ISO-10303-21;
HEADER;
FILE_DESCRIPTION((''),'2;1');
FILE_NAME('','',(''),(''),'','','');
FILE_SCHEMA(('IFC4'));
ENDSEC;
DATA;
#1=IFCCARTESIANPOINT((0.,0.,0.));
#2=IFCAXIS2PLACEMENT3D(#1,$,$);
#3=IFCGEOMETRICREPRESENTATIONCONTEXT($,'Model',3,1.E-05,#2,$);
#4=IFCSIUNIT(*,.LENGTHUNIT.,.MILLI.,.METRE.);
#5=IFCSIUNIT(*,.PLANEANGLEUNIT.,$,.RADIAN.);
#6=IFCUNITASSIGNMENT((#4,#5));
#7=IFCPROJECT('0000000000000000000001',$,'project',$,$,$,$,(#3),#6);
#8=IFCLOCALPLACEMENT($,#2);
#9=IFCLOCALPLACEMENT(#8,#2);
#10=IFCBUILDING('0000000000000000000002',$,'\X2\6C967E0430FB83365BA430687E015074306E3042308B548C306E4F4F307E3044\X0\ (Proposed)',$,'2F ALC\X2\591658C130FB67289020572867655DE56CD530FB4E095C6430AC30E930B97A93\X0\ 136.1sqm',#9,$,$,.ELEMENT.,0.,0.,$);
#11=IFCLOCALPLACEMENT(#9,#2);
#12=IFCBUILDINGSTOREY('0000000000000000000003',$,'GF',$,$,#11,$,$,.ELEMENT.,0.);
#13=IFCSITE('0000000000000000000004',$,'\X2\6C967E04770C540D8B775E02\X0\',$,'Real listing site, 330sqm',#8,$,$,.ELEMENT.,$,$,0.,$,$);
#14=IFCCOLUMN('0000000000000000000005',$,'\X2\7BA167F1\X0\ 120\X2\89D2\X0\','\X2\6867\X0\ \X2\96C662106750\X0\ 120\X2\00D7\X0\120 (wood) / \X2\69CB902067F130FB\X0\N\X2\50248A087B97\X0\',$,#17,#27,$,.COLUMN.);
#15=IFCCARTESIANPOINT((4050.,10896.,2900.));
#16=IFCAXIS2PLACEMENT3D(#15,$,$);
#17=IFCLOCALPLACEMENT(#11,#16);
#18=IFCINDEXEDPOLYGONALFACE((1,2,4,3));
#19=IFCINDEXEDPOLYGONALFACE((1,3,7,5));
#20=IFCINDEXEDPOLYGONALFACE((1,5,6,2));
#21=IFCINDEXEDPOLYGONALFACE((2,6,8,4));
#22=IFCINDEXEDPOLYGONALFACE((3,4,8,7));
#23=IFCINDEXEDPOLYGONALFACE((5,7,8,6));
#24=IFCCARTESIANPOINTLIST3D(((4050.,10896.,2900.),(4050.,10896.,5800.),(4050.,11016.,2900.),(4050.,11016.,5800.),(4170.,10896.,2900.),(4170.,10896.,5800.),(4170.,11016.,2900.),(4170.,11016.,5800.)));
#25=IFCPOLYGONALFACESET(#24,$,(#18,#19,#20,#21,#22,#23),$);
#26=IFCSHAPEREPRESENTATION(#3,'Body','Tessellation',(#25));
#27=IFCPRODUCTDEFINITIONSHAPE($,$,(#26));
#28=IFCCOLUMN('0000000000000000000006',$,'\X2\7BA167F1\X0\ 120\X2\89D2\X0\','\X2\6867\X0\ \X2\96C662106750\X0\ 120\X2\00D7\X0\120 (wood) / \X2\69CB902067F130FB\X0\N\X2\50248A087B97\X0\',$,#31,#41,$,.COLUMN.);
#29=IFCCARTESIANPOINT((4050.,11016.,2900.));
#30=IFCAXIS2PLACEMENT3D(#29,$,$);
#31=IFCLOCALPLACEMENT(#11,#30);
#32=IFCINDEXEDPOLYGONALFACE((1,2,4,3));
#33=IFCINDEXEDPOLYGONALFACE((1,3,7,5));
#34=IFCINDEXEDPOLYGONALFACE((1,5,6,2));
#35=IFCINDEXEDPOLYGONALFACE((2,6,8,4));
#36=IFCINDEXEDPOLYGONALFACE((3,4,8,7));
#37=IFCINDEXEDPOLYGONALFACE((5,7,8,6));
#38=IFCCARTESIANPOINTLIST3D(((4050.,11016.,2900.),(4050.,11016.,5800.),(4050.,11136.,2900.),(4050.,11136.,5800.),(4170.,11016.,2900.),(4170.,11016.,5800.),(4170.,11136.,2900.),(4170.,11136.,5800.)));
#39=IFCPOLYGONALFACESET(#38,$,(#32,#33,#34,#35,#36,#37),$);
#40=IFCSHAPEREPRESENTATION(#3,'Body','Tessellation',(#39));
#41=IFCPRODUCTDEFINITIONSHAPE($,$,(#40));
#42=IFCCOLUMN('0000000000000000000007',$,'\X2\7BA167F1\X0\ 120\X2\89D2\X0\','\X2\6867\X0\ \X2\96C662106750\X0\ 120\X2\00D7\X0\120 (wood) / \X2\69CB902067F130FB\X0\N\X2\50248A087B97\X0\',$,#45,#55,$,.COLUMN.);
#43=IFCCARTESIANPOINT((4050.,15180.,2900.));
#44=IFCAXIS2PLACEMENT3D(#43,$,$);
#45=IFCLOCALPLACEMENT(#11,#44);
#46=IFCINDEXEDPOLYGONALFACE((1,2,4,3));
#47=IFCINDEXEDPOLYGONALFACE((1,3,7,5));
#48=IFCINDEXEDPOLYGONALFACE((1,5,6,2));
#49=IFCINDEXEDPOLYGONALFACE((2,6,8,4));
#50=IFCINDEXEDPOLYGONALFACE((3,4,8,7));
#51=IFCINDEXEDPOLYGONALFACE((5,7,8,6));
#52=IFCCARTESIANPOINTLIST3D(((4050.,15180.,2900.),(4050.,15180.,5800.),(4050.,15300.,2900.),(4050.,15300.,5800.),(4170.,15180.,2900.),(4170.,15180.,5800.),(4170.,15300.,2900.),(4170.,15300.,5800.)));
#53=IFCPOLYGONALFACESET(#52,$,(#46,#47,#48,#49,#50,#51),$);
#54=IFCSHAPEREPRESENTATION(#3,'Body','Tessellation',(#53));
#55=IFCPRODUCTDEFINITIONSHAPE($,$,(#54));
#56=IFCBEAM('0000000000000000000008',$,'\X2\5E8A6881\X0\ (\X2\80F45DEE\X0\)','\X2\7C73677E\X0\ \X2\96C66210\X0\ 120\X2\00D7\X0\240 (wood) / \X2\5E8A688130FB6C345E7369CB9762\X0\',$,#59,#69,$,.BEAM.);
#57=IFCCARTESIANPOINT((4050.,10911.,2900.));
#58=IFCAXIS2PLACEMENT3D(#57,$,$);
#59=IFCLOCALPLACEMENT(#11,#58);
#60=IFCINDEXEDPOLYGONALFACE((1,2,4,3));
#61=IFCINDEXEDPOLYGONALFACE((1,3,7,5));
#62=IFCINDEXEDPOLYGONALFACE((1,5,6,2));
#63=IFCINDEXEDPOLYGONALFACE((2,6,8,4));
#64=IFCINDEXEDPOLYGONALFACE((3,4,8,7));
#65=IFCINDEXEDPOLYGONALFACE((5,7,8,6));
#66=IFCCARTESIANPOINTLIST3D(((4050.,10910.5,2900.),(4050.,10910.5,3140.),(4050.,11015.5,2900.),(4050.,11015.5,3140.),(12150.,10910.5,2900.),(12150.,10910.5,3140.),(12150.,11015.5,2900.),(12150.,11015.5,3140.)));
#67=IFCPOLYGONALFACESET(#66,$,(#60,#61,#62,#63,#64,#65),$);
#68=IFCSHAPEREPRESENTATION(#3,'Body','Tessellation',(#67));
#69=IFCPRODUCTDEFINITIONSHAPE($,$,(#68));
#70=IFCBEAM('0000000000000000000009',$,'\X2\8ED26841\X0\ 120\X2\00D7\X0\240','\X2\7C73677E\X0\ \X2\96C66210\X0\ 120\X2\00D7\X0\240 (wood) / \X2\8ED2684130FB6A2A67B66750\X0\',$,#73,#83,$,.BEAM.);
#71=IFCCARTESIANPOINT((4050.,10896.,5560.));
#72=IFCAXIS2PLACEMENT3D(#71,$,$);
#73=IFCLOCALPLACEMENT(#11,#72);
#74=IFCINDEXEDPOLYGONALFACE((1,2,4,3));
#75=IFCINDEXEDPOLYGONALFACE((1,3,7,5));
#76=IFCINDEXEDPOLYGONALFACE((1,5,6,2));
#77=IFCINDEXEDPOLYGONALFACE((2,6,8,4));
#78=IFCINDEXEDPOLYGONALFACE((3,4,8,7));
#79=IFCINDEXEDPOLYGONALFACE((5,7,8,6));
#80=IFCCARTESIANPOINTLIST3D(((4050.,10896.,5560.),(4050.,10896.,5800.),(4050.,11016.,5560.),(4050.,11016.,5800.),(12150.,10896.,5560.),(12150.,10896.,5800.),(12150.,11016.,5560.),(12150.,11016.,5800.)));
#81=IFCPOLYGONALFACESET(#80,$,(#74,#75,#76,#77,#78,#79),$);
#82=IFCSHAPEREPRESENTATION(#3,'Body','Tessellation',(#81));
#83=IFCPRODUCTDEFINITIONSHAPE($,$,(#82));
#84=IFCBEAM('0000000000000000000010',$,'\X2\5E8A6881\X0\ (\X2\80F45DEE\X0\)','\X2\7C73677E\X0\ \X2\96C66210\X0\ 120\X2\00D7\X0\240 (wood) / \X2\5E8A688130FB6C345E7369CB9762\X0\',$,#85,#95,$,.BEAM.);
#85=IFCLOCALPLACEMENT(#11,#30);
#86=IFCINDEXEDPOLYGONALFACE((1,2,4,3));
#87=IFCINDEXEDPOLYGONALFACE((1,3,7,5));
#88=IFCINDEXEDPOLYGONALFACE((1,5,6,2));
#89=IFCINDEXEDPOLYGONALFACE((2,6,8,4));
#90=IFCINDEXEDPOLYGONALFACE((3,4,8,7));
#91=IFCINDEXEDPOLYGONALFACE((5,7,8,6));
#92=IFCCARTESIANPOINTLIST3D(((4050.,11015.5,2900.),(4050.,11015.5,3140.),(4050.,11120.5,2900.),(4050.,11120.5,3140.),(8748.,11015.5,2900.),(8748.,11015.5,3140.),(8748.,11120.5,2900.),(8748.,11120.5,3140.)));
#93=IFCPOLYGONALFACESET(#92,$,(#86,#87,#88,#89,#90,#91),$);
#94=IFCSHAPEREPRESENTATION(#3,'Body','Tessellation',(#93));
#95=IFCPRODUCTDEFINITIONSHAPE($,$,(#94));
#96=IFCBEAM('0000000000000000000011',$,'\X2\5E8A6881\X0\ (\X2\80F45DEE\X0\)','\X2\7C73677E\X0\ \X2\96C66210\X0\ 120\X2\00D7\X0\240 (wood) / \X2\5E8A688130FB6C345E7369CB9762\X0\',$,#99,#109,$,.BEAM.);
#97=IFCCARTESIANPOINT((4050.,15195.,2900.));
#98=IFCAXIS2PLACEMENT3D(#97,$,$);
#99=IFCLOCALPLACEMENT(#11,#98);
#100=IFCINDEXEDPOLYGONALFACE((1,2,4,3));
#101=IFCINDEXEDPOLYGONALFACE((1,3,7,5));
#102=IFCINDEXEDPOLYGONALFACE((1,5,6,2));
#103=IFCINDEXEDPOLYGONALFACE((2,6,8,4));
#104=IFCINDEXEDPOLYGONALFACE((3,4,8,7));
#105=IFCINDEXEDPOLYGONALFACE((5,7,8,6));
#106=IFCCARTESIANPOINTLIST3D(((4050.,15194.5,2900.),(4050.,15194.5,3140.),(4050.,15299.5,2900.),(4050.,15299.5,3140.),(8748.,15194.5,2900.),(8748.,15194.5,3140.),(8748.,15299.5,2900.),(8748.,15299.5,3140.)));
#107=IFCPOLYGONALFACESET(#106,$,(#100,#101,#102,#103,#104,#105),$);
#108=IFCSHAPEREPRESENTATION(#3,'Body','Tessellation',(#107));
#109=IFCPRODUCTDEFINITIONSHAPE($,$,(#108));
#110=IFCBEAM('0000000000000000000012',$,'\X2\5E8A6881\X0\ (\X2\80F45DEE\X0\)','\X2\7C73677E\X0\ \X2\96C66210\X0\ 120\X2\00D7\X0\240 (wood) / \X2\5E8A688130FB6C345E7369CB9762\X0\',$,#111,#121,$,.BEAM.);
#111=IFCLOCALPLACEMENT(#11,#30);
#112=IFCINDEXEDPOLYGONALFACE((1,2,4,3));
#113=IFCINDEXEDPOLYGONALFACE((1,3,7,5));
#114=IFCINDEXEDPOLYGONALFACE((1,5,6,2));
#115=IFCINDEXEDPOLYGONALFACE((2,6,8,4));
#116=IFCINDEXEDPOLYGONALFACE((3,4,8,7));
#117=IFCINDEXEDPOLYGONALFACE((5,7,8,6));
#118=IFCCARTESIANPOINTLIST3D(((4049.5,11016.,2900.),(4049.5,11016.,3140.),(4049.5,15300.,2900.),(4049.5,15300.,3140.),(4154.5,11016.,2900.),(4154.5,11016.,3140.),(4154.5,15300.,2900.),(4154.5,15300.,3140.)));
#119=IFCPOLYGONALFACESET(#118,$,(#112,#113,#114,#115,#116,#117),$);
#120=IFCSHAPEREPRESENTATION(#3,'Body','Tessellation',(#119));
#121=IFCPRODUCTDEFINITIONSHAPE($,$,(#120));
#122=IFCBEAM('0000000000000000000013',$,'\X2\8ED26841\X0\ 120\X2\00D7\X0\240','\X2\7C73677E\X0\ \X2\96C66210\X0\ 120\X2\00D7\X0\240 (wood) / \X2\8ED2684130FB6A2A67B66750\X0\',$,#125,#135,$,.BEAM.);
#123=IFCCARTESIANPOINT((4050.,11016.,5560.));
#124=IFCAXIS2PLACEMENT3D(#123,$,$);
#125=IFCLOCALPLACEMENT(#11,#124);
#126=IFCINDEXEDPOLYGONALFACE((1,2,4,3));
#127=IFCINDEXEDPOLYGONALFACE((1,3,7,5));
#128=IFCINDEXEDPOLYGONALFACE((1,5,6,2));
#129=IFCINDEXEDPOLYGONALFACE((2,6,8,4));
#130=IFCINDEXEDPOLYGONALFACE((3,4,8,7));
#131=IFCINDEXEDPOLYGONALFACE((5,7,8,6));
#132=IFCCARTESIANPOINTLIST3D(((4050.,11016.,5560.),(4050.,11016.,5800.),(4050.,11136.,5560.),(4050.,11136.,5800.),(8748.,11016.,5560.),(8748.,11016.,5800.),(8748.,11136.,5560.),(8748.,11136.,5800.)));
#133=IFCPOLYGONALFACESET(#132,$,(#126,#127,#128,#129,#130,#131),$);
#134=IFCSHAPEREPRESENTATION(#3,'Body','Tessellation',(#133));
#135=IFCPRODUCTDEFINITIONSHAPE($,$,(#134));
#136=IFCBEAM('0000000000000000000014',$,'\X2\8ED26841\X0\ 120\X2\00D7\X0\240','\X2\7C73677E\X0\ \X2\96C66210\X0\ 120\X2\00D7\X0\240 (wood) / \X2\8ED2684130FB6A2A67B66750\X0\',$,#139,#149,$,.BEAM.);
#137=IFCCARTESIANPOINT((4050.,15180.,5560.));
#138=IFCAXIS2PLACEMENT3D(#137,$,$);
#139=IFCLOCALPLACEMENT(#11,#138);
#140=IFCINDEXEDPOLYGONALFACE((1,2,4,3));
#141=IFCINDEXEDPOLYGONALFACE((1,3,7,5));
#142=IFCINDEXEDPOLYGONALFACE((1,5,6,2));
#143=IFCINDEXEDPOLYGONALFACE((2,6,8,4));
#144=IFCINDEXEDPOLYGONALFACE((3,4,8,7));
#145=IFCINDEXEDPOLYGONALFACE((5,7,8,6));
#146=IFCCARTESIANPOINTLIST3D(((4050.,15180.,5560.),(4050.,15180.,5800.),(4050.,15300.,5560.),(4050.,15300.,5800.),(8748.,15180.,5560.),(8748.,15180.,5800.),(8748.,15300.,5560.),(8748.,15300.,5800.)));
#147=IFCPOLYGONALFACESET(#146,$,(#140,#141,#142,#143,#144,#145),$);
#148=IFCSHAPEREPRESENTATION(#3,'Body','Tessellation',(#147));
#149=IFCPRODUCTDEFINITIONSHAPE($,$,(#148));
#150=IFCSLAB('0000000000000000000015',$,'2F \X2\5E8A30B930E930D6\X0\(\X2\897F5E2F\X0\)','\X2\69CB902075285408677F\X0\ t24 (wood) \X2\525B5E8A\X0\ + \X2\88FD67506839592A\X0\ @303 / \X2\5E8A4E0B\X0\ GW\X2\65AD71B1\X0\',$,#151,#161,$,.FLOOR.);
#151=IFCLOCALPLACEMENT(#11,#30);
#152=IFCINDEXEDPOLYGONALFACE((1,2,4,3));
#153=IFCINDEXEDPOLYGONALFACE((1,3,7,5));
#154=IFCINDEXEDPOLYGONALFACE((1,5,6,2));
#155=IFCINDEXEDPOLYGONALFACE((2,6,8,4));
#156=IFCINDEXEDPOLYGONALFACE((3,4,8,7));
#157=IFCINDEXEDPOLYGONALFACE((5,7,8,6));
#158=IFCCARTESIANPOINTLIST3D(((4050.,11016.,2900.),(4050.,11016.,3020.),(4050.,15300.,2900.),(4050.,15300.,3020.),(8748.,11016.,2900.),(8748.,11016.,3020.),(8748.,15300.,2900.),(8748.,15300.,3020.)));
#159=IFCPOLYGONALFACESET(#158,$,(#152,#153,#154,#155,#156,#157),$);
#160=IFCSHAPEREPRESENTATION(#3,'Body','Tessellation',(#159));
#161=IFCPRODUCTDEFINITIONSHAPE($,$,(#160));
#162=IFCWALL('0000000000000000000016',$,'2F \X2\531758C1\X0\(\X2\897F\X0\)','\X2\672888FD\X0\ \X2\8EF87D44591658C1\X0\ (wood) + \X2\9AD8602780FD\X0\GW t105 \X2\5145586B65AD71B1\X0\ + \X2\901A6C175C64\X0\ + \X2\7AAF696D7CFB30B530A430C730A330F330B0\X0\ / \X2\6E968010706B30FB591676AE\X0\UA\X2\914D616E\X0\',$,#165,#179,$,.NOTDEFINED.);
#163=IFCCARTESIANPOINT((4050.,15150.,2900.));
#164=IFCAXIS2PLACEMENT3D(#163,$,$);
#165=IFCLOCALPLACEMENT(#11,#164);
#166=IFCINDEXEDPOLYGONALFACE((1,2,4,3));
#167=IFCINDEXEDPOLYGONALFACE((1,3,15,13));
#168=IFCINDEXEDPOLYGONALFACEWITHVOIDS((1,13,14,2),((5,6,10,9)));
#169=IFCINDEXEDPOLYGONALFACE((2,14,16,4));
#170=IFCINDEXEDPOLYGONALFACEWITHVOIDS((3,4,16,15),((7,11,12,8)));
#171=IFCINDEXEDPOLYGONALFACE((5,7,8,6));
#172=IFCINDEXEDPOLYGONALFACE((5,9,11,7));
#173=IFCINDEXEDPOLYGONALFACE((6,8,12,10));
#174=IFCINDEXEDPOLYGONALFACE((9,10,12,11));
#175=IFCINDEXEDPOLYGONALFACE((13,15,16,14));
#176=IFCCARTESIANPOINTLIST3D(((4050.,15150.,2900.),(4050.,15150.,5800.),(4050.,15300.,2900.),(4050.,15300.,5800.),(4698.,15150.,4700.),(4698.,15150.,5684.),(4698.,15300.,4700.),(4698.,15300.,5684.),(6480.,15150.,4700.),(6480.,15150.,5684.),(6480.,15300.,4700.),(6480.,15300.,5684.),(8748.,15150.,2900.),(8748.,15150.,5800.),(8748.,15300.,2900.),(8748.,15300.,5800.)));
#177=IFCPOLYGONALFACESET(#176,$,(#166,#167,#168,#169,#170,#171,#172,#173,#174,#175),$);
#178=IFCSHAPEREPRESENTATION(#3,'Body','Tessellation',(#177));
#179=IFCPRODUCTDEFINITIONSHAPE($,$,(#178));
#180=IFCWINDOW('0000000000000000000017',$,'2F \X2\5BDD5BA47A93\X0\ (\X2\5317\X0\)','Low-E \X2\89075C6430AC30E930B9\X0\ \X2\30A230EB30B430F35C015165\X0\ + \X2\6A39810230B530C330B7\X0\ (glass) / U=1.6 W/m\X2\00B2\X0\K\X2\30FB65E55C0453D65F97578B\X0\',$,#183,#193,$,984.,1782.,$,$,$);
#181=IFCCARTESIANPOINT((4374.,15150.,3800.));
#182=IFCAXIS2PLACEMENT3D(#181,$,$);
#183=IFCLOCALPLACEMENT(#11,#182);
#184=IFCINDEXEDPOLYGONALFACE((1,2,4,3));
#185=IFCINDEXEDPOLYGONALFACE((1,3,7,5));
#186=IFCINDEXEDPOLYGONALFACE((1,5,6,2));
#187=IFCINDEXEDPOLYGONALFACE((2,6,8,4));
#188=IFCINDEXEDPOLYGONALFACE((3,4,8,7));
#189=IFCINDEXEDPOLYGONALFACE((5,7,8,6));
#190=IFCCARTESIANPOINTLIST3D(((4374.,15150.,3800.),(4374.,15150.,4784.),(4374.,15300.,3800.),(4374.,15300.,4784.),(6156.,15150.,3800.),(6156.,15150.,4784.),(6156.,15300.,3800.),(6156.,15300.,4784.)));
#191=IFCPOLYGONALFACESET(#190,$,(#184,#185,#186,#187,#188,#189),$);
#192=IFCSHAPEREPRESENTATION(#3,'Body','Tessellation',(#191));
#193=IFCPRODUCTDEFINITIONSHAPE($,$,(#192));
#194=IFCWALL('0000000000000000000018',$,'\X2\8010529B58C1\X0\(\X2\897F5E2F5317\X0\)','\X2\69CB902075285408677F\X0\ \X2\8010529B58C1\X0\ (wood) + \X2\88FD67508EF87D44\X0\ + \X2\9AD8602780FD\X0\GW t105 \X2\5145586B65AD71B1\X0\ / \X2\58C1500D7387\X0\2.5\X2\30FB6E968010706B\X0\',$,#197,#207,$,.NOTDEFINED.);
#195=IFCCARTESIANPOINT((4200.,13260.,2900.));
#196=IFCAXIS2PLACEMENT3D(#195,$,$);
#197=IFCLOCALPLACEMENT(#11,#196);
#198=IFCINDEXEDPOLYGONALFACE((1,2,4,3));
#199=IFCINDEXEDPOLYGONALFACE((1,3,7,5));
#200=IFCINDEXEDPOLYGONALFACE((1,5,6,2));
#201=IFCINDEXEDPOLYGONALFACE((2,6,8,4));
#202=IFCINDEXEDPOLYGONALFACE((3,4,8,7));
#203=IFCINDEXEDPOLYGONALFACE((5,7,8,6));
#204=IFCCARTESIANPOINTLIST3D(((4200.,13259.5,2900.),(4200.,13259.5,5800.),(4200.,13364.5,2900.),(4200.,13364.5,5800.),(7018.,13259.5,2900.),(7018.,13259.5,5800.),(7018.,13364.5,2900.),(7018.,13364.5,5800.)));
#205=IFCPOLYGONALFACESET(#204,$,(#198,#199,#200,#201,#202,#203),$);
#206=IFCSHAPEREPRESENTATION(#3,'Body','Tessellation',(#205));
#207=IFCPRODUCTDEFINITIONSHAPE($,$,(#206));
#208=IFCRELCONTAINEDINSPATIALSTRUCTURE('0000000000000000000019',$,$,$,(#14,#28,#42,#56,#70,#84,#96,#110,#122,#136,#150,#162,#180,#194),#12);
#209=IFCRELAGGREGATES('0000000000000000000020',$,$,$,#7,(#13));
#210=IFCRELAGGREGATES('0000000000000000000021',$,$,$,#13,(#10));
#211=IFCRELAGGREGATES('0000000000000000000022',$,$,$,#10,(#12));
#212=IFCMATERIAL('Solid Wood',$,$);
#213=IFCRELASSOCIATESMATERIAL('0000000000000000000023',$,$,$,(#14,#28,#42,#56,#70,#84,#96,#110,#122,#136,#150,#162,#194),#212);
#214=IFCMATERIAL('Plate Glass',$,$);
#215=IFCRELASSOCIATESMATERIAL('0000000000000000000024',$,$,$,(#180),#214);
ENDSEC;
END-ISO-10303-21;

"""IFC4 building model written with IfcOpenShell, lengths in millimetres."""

from ifc_helpers import new_model, si_unit, frame, frame_2d, origin, place, context, project, spatial, rectangle, extrude, material, element, fill, save


model = new_model("IFC4")

# Units and contexts
model_context = context("Model", 3, precision=1e-05, world=origin())
ifc_project = project(units=[si_unit("LENGTHUNIT", "METRE", prefix="MILLI"), si_unit("PLANEANGLEUNIT", "RADIAN")], contexts=[model_context])

# Site, building, storey
site_placement = place(None, origin())
site = spatial("IfcSite", under=ifc_project, at=site_placement, Name="沖縄県名護市", ObjectType="Real listing site, 330sqm", CompositionType="ELEMENT", RefElevation=0.0)
building_placement = place(site_placement, origin())
building = spatial("IfcBuilding", under=site, at=building_placement, Name="沖縄・茶室と縁側のある和の住まい (Proposed)", ObjectType="2F ALC外壁・木造在来工法・三層ガラス窓 136.1sqm", CompositionType="ELEMENT", ElevationOfRefHeight=0.0, ElevationOfTerrain=0.0)
storey_placement = place(building_placement, origin())
storey = spatial("IfcBuildingStorey", under=building, at=storey_placement, Name="GF", CompositionType="ELEMENT", Elevation=0.0)

# Columns
ifc_material_1 = material(Name="Solid Wood")
column_1_placement = place(storey_placement, frame((4050.0, 10896.0, 2900.0)))
element("IfcColumn", 1, at=column_1_placement, inside=storey, material=ifc_material_1, Name="管柱 120角", Description="桧 集成材 120×120 (wood) / 構造柱・N値計算", PredefinedType="COLUMN", context=model_context, shape_type="SweptSolid", body=[
    extrude(rectangle(XDim=120.0, YDim=120.0, at=frame_2d((60.0, 60.0))), frame((4050.0, 10896.0, 2900.0)), (0.0, 0.0, 1.0), 2900.0),
])
column_2_placement = place(storey_placement, frame((4050.0, 11016.0, 2900.0)))
element("IfcColumn", 2, at=column_2_placement, inside=storey, material=ifc_material_1, Name="管柱 120角", Description="桧 集成材 120×120 (wood) / 構造柱・N値計算", PredefinedType="COLUMN", context=model_context, shape_type="SweptSolid", body=[
    extrude(rectangle(XDim=120.0, YDim=120.0, at=frame_2d((60.0, 60.0))), frame((4050.0, 11016.0, 2900.0)), (0.0, 0.0, 1.0), 2900.0),
])
column_3_placement = place(storey_placement, frame((4050.0, 15180.0, 2900.0)))
element("IfcColumn", 3, at=column_3_placement, inside=storey, material=ifc_material_1, Name="管柱 120角", Description="桧 集成材 120×120 (wood) / 構造柱・N値計算", PredefinedType="COLUMN", context=model_context, shape_type="SweptSolid", body=[
    extrude(rectangle(XDim=120.0, YDim=120.0, at=frame_2d((60.0, 60.0))), frame((4050.0, 15180.0, 2900.0)), (0.0, 0.0, 1.0), 2900.0),
])

# Beams
beam_1_placement = place(storey_placement, frame((4050.0, 10911.0, 2900.0)))
element("IfcBeam", 4, at=beam_1_placement, inside=storey, material=ifc_material_1, Name="床梁 (胴差)", Description="米松 集成 120×240 (wood) / 床梁・水平構面", PredefinedType="BEAM", context=model_context, shape_type="SweptSolid", body=[
    extrude(rectangle(XDim=8100.0, YDim=105.0, at=frame_2d((4050.0, 52.0))), frame((4050.0, 10911.0, 2900.0)), (0.0, 0.0, 1.0), 240.0),
])
beam_2_placement = place(storey_placement, frame((4050.0, 10896.0, 5560.0)))
element("IfcBeam", 5, at=beam_2_placement, inside=storey, material=ifc_material_1, Name="軒桁 120×240", Description="米松 集成 120×240 (wood) / 軒桁・横架材", PredefinedType="BEAM", context=model_context, shape_type="SweptSolid", body=[
    extrude(rectangle(XDim=8100.0, YDim=120.0, at=frame_2d((4050.0, 60.0))), frame((4050.0, 10896.0, 5560.0)), (0.0, 0.0, 1.0), 240.0),
])
beam_3_placement = place(storey_placement, frame((4050.0, 11016.0, 2900.0)))
element("IfcBeam", 6, at=beam_3_placement, inside=storey, material=ifc_material_1, Name="床梁 (胴差)", Description="米松 集成 120×240 (wood) / 床梁・水平構面", PredefinedType="BEAM", context=model_context, shape_type="SweptSolid", body=[
    extrude(rectangle(XDim=4698.0, YDim=105.0, at=frame_2d((2349.0, 52.0))), frame((4050.0, 11016.0, 2900.0)), (0.0, 0.0, 1.0), 240.0),
])
beam_4_placement = place(storey_placement, frame((4050.0, 15195.0, 2900.0)))
element("IfcBeam", 7, at=beam_4_placement, inside=storey, material=ifc_material_1, Name="床梁 (胴差)", Description="米松 集成 120×240 (wood) / 床梁・水平構面", PredefinedType="BEAM", context=model_context, shape_type="SweptSolid", body=[
    extrude(rectangle(XDim=4698.0, YDim=105.0, at=frame_2d((2349.0, 52.0))), frame((4050.0, 15195.0, 2900.0)), (0.0, 0.0, 1.0), 240.0),
])
beam_5_placement = place(storey_placement, frame((4050.0, 11016.0, 2900.0)))
element("IfcBeam", 8, at=beam_5_placement, inside=storey, material=ifc_material_1, Name="床梁 (胴差)", Description="米松 集成 120×240 (wood) / 床梁・水平構面", PredefinedType="BEAM", context=model_context, shape_type="SweptSolid", body=[
    extrude(rectangle(XDim=105.0, YDim=4284.0, at=frame_2d((52.0, 2142.0))), frame((4050.0, 11016.0, 2900.0)), (0.0, 0.0, 1.0), 240.0),
])
beam_6_placement = place(storey_placement, frame((4050.0, 11016.0, 5560.0)))
element("IfcBeam", 9, at=beam_6_placement, inside=storey, material=ifc_material_1, Name="軒桁 120×240", Description="米松 集成 120×240 (wood) / 軒桁・横架材", PredefinedType="BEAM", context=model_context, shape_type="SweptSolid", body=[
    extrude(rectangle(XDim=4698.0, YDim=120.0, at=frame_2d((2349.0, 60.0))), frame((4050.0, 11016.0, 5560.0)), (0.0, 0.0, 1.0), 240.0),
])
beam_7_placement = place(storey_placement, frame((4050.0, 15180.0, 5560.0)))
element("IfcBeam", 10, at=beam_7_placement, inside=storey, material=ifc_material_1, Name="軒桁 120×240", Description="米松 集成 120×240 (wood) / 軒桁・横架材", PredefinedType="BEAM", context=model_context, shape_type="SweptSolid", body=[
    extrude(rectangle(XDim=4698.0, YDim=120.0, at=frame_2d((2349.0, 60.0))), frame((4050.0, 15180.0, 5560.0)), (0.0, 0.0, 1.0), 240.0),
])

# Slab
slab_placement = place(storey_placement, frame((4050.0, 11016.0, 2900.0)))
element("IfcSlab", 11, at=slab_placement, inside=storey, material=ifc_material_1, Name="2F 床スラブ(西帯)", Description="構造用合板 t24 (wood) 剛床 + 製材根太 @303 / 床下 GW断熱", PredefinedType="FLOOR", context=model_context, shape_type="SweptSolid", body=[
    extrude(rectangle(XDim=4698.0, YDim=4284.0, at=frame_2d((2349.0, 2142.0))), frame((4050.0, 11016.0, 2900.0)), (0.0, 0.0, 1.0), 120.0),
])

# Wall, opening, window
wall_1_placement = place(storey_placement, frame((4050.0, 15150.0, 2900.0)))
wall_1 = element("IfcWall", 12, at=wall_1_placement, inside=storey, material=ifc_material_1, Name="2F 北壁(西)", Description="木製 軸組外壁 (wood) + 高性能GW t105 充填断熱 + 通気層 + 窯業系サイディング / 準耐火・外皮UA配慮", PredefinedType="NOTDEFINED", context=model_context, shape_type="SweptSolid", body=[
    extrude(rectangle(XDim=4698.0, YDim=150.0, at=frame_2d((2349.0, 75.0))), frame((4050.0, 15150.0, 2900.0)), (0.0, 0.0, 1.0), 2900.0),
])
opening_placement = place(storey_placement, frame((4374.0, 15150.0, 3800.0)))
opening = element("IfcOpeningElement", 13, at=opening_placement, cuts=wall_1, PredefinedType="NOTDEFINED", context=model_context, shape_type="SweptSolid", body=[
    extrude(rectangle(XDim=1782.0, YDim=150.0, at=frame_2d((891.0, 75.0))), frame((4374.0, 15150.0, 3800.0)), (0.0, 0.0, 1.0), 984.0),
])
ifc_material_2 = material(Name="Plate Glass")
window_placement = place(storey_placement, frame((4374.0, 15150.0, 3800.0)))
window = element("IfcWindow", 14, at=window_placement, inside=storey, material=ifc_material_2, Name="2F 寝室窓 (北)", Description="Low-E 複層ガラス アルゴン封入 + 樹脂サッシ (glass) / U=1.6 W/m²K・日射取得型", OverallHeight=984.0, OverallWidth=1782.0, context=model_context, shape_type="SweptSolid", body=[
    extrude(rectangle(XDim=1782.0, YDim=150.0, at=frame_2d((891.0, 75.0))), frame((4374.0, 15150.0, 3800.0)), (0.0, 0.0, 1.0), 984.0),
])
fill(opening, window)

# Wall
wall_2_placement = place(storey_placement, frame((4200.0, 13260.0, 2900.0)))
element("IfcWall", 15, at=wall_2_placement, inside=storey, material=ifc_material_1, Name="耐力壁(西帯北)", Description="構造用合板 耐力壁 (wood) + 製材軸組 + 高性能GW t105 充填断熱 / 壁倍率2.5・準耐火", PredefinedType="NOTDEFINED", context=model_context, shape_type="SweptSolid", body=[
    extrude(rectangle(XDim=2818.0, YDim=105.0, at=frame_2d((1409.0, 52.0))), frame((4200.0, 13260.0, 2900.0)), (0.0, 0.0, 1.0), 2900.0),
])

save(model, "model.ifc")
